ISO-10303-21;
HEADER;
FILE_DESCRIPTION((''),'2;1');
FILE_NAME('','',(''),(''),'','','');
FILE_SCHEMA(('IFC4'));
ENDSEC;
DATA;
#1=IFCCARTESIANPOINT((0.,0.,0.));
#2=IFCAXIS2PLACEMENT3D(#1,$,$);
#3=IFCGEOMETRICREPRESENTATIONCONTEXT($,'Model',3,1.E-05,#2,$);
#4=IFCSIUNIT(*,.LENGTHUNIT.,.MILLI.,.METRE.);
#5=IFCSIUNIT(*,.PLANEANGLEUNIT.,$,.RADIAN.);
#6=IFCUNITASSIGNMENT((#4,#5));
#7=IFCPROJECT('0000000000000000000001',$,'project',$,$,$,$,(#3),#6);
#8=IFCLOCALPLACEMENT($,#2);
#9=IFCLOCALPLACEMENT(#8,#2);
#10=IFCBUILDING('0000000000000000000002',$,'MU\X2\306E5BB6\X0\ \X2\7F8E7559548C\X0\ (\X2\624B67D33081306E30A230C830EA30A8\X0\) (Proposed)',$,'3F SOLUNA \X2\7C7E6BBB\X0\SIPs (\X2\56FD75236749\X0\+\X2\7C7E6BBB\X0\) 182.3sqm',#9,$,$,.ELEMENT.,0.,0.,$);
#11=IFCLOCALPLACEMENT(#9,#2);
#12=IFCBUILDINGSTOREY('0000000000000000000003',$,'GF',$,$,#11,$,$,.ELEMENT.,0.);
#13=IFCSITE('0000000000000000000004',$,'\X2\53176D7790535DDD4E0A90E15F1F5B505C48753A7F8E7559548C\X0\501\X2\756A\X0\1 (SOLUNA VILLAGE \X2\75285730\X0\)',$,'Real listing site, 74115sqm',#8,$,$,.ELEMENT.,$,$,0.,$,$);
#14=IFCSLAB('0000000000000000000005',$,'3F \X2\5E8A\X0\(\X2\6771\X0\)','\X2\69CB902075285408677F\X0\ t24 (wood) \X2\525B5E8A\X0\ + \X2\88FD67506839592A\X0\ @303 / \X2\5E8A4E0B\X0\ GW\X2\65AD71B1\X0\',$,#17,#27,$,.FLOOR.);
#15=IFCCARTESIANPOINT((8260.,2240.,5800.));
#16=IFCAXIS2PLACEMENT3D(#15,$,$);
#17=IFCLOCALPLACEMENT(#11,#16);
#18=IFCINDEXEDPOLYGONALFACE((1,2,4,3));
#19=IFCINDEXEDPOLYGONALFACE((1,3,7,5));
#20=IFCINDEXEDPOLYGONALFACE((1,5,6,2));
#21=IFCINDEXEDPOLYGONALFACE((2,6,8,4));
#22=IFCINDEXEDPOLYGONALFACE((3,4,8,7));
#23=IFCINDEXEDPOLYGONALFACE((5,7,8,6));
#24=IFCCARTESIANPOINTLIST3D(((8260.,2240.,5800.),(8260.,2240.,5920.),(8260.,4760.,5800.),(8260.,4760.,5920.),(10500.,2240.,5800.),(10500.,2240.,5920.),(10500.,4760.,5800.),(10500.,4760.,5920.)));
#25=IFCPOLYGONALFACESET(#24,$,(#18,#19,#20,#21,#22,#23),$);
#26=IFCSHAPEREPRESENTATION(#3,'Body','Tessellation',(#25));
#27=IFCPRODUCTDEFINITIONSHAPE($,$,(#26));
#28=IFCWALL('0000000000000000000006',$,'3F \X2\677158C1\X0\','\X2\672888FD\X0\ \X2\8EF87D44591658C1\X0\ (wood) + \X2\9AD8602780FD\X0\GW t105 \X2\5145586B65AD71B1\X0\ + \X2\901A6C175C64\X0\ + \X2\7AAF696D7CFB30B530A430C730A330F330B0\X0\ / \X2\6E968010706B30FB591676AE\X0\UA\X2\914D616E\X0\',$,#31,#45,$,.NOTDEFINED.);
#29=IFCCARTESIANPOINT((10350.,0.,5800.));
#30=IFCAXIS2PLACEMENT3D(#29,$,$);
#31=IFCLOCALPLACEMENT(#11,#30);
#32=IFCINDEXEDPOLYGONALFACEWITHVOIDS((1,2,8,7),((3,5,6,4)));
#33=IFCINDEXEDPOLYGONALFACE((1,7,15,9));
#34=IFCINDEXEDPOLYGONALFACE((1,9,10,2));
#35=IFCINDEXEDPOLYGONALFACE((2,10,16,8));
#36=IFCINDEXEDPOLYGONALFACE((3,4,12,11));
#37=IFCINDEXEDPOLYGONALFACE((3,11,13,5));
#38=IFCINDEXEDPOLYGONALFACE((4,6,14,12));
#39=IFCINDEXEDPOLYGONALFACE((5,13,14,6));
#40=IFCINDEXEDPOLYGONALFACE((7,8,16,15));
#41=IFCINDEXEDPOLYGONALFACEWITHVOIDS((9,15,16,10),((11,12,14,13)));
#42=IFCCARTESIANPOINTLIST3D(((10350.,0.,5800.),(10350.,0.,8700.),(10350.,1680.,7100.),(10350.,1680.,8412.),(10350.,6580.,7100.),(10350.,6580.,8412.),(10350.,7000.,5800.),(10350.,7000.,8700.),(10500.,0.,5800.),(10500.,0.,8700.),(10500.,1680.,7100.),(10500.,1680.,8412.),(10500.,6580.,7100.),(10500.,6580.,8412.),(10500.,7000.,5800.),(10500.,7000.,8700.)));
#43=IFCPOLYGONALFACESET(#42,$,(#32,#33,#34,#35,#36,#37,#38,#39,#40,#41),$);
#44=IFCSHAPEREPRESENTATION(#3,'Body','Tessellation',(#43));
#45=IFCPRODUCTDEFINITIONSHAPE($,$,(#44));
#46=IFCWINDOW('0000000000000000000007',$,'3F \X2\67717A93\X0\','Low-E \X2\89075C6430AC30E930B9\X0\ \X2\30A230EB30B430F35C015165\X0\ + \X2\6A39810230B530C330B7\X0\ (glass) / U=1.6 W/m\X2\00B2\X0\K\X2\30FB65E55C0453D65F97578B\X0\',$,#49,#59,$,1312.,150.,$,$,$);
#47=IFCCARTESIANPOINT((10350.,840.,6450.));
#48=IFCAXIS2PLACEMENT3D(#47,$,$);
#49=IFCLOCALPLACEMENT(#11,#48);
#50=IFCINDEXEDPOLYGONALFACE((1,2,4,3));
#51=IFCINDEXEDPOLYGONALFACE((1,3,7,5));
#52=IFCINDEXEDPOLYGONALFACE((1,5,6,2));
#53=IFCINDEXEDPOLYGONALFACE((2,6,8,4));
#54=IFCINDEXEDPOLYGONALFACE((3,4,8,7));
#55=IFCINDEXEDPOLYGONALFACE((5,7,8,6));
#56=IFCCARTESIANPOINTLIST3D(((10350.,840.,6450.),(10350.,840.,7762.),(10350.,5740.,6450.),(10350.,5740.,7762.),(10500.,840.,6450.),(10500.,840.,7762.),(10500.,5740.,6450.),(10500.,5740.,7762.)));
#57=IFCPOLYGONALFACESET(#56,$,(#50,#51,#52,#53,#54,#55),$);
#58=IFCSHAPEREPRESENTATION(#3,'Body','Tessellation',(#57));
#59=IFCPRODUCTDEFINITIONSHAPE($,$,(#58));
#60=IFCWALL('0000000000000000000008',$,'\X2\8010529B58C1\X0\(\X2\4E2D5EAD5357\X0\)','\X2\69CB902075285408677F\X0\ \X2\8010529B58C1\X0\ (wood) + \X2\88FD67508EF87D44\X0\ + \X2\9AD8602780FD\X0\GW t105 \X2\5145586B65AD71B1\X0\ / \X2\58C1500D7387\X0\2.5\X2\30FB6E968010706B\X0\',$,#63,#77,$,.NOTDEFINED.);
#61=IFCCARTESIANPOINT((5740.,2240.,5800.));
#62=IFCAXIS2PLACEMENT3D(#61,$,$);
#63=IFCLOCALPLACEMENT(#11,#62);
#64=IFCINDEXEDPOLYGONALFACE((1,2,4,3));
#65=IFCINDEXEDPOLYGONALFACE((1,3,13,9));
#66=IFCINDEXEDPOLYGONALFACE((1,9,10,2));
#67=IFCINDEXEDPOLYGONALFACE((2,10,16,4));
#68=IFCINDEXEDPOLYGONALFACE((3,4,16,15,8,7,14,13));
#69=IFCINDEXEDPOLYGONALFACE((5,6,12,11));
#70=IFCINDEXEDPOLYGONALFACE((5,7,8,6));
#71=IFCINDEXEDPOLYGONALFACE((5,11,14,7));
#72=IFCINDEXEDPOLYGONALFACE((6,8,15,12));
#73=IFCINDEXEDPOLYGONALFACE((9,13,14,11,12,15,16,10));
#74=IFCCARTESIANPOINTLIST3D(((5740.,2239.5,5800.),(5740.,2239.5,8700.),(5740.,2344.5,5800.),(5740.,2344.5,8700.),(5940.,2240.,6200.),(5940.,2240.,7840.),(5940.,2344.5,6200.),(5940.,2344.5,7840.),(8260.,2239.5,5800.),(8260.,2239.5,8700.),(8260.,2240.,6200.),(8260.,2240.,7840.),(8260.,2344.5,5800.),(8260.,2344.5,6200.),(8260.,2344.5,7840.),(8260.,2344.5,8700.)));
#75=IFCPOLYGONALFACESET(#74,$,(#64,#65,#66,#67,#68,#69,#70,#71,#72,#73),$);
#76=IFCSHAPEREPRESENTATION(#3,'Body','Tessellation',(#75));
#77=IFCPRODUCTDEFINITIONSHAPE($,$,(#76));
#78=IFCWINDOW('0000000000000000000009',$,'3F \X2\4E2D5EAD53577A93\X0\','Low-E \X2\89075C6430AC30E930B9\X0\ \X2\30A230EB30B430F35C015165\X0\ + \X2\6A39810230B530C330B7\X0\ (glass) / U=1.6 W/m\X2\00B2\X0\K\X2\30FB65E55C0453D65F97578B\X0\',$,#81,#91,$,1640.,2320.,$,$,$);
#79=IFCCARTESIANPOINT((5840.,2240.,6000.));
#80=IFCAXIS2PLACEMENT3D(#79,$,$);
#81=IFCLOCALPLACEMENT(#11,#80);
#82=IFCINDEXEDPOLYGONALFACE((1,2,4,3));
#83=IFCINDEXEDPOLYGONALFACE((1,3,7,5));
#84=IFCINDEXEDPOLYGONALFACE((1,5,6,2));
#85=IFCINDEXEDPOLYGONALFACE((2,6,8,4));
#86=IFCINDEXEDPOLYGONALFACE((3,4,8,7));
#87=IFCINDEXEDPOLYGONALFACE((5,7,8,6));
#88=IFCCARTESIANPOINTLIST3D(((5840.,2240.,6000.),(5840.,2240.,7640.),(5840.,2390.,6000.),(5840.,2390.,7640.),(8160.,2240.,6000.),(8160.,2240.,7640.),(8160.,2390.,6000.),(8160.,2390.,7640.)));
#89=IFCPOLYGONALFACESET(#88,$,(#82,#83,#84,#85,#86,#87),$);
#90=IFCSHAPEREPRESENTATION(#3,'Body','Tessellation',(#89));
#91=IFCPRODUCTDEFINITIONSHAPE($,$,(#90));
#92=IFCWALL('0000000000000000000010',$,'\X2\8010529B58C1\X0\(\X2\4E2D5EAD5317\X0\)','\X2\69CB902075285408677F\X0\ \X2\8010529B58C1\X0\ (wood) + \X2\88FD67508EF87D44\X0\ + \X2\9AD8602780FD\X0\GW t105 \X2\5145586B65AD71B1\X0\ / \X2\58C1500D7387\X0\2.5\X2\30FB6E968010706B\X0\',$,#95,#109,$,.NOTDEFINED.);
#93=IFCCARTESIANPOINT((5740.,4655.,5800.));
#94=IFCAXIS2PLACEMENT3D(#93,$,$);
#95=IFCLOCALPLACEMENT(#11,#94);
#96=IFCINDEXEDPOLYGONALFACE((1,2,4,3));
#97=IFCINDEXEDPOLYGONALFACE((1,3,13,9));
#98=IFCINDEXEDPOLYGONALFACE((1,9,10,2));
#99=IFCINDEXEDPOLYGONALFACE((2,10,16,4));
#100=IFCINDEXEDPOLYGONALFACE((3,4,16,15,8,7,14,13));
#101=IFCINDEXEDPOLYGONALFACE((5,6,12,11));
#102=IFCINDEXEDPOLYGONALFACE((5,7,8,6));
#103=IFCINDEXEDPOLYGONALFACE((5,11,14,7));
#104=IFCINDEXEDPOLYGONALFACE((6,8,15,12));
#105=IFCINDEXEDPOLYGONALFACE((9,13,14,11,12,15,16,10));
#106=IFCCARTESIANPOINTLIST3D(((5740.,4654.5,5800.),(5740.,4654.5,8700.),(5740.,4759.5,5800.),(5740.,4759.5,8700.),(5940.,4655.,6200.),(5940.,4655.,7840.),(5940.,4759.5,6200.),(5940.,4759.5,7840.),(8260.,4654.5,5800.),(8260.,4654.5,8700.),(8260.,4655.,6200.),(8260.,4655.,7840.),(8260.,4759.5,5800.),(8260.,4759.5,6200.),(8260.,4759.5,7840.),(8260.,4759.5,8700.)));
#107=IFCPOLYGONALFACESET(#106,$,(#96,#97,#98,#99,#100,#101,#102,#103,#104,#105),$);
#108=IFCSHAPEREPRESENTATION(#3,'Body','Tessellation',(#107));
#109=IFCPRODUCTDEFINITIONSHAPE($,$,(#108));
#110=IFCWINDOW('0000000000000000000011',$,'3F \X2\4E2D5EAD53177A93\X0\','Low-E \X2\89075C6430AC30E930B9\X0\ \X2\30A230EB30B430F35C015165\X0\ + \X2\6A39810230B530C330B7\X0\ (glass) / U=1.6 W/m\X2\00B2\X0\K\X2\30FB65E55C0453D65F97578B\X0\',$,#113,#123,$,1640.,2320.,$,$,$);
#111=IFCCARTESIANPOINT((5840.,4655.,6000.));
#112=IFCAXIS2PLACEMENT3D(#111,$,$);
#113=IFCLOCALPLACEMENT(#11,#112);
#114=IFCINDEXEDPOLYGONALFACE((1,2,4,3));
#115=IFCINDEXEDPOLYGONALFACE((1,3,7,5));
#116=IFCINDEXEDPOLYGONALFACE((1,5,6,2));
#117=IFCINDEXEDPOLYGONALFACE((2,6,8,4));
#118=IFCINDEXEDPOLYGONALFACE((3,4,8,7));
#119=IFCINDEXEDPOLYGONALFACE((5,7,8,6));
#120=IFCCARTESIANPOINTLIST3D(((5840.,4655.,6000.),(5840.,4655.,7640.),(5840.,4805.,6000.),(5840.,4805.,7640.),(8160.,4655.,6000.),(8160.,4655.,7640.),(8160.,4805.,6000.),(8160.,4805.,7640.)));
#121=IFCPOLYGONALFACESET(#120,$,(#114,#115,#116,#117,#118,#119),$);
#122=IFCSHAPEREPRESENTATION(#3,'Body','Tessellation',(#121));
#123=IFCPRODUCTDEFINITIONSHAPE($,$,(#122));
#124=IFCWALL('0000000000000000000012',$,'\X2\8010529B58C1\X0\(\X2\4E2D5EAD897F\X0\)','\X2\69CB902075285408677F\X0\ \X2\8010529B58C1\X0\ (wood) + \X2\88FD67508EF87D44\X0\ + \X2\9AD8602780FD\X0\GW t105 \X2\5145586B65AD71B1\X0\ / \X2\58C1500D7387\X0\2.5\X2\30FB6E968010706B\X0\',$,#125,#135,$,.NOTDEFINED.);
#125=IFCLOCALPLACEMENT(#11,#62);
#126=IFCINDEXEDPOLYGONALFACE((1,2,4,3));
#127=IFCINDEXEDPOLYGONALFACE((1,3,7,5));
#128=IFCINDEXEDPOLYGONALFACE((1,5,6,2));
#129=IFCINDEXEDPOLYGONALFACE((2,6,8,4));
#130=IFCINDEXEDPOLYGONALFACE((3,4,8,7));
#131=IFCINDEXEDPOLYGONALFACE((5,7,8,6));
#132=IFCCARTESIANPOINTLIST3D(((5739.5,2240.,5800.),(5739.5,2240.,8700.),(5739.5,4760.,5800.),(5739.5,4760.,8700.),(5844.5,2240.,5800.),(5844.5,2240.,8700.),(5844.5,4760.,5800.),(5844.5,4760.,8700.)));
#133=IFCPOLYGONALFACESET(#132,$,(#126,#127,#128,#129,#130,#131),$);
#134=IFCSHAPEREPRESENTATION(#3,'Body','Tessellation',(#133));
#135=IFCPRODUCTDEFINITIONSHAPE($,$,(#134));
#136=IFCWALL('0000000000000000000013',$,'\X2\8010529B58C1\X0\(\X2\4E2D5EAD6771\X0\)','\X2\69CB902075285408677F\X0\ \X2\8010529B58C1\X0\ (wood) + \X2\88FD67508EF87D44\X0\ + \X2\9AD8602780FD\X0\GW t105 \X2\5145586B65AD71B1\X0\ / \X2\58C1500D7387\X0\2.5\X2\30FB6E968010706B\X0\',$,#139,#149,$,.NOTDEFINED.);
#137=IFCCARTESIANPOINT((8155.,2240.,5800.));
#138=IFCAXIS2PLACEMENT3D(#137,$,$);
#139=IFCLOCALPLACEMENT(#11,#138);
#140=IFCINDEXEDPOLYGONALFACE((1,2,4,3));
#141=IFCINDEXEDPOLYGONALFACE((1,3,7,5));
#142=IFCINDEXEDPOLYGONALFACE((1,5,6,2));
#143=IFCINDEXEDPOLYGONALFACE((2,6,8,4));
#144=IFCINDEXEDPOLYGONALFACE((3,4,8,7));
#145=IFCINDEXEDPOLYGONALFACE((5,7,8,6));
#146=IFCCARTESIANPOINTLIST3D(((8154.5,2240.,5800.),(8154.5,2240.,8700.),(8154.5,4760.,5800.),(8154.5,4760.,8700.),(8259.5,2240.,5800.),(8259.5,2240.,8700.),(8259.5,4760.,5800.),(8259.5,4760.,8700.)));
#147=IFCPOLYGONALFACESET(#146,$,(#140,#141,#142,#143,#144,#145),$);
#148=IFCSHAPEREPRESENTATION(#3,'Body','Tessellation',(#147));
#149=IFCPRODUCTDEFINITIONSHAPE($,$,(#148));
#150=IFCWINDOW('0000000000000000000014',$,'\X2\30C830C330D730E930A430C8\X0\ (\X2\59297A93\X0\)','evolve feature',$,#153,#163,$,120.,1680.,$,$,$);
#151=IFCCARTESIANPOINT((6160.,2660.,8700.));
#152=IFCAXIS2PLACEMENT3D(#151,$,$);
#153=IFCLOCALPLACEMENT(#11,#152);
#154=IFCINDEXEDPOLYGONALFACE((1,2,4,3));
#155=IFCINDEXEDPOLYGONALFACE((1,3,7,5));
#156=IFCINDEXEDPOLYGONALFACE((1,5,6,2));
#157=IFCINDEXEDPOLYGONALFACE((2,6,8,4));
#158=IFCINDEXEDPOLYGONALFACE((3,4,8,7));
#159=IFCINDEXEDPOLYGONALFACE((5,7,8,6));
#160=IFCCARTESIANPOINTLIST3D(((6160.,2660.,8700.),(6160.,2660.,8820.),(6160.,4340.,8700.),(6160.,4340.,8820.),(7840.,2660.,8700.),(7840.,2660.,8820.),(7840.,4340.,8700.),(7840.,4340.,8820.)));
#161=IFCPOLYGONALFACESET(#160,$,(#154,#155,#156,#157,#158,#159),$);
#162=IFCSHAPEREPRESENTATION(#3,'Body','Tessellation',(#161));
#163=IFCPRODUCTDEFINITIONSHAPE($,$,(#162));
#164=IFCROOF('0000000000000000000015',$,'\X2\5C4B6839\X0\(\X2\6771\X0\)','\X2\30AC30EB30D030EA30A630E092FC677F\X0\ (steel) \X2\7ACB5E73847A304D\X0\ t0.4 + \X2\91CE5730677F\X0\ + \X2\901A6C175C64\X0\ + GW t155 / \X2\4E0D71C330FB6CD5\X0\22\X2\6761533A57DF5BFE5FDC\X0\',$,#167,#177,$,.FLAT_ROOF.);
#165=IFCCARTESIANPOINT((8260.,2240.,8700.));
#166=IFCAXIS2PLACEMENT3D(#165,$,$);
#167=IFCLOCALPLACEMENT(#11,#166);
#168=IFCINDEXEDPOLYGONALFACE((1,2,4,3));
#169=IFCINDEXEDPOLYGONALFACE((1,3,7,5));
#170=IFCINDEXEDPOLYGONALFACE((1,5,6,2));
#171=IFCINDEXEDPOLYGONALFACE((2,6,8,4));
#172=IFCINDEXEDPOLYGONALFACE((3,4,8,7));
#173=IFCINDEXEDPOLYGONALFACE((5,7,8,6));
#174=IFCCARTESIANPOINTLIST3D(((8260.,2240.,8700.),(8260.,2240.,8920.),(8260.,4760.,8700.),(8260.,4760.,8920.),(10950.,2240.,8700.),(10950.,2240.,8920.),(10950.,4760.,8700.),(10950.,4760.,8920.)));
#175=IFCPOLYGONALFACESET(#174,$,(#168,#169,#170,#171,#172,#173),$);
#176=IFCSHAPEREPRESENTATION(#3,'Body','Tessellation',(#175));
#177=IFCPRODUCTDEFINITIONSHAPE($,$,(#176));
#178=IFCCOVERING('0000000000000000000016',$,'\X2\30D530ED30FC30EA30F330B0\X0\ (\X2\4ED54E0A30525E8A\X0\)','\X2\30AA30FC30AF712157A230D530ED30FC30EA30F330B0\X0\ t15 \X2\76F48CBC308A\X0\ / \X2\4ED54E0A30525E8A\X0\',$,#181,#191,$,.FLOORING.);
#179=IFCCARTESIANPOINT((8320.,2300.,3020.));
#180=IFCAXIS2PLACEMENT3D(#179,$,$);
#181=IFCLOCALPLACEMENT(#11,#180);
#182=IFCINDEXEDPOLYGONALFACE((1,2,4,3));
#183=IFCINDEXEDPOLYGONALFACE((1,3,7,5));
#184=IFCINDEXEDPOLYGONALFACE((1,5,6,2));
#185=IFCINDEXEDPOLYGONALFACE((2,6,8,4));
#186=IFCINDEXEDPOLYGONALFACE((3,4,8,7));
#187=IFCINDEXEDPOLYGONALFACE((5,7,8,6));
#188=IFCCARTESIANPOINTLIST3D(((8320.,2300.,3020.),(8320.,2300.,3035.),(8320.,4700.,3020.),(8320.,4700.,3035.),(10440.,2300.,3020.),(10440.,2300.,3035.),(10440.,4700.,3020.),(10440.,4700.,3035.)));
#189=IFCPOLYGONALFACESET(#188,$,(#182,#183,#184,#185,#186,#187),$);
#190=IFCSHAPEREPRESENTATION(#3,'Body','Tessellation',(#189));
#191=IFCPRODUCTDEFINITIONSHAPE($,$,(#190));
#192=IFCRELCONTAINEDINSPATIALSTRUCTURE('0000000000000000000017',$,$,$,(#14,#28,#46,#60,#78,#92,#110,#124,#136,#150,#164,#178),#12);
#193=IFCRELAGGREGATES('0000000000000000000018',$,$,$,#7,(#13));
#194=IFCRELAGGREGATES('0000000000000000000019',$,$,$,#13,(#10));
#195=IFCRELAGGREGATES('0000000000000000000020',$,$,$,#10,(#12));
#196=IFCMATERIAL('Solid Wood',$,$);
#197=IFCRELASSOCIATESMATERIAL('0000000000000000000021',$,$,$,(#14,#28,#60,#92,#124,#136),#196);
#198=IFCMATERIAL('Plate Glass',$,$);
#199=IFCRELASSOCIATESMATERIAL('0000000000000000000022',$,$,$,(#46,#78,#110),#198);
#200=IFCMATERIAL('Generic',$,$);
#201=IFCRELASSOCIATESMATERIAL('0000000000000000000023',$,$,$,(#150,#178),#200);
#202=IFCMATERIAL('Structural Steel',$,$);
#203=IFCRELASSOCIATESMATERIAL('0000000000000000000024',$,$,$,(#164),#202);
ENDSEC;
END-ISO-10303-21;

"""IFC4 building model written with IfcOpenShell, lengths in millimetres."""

from ifc_helpers import new_model, si_unit, frame, frame_2d, origin, place, context, project, spatial, rectangle, extrude, material, element, fill, save


model = new_model("IFC4")

# Units and contexts
model_context = context("Model", 3, precision=1e-05, world=origin())
ifc_project = project(units=[si_unit("LENGTHUNIT", "METRE", prefix="MILLI"), si_unit("PLANEANGLEUNIT", "RADIAN")], contexts=[model_context])

# Site, building, storey
site_placement = place(None, origin())
site = spatial("IfcSite", under=ifc_project, at=site_placement, Name="北海道川上郡弟子屈町美留和501番1 (SOLUNA VILLAGE 用地)", ObjectType="Real listing site, 74115sqm", CompositionType="ELEMENT", RefElevation=0.0)
building_placement = place(site_placement, origin())
building = spatial("IfcBuilding", under=site, at=building_placement, Name="MUの家 美留和 (手染めのアトリエ) (Proposed)", ObjectType="3F SOLUNA 籾殻SIPs (国産杉+籾殻) 182.3sqm", CompositionType="ELEMENT", ElevationOfRefHeight=0.0, ElevationOfTerrain=0.0)
storey_placement = place(building_placement, origin())
storey = spatial("IfcBuildingStorey", under=building, at=storey_placement, Name="GF", CompositionType="ELEMENT", Elevation=0.0)

# Slab
ifc_material_1 = material(Name="Solid Wood")
slab_placement = place(storey_placement, frame((8260.0, 2240.0, 5800.0)))
element("IfcSlab", 1, at=slab_placement, inside=storey, material=ifc_material_1, Name="3F 床(東)", Description="構造用合板 t24 (wood) 剛床 + 製材根太 @303 / 床下 GW断熱", PredefinedType="FLOOR", context=model_context, shape_type="SweptSolid", body=[
    extrude(rectangle(XDim=2240.0, YDim=2520.0, at=frame_2d((1120.0, 1260.0))), frame((8260.0, 2240.0, 5800.0)), (0.0, 0.0, 1.0), 120.0),
])

# Walls, openings, windows
wall_1_placement = place(storey_placement, frame((10350.0, 0.0, 5800.0)))
wall_1 = element("IfcWall", 2, at=wall_1_placement, inside=storey, material=ifc_material_1, Name="3F 東壁", Description="木製 軸組外壁 (wood) + 高性能GW t105 充填断熱 + 通気層 + 窯業系サイディング / 準耐火・外皮UA配慮", PredefinedType="NOTDEFINED", context=model_context, shape_type="SweptSolid", body=[
    extrude(rectangle(XDim=150.0, YDim=7000.0, at=frame_2d((75.0, 3500.0))), frame((10350.0, 0.0, 5800.0)), (0.0, 0.0, 1.0), 2900.0),
])
opening_1_placement = place(storey_placement, frame((10350.0, 840.0, 6450.0)))
opening_1 = element("IfcOpeningElement", 3, at=opening_1_placement, cuts=wall_1, PredefinedType="NOTDEFINED", context=model_context, shape_type="SweptSolid", body=[
    extrude(rectangle(XDim=150.0, YDim=4900.0, at=frame_2d((75.0, 2450.0))), frame((10350.0, 840.0, 6450.0)), (0.0, 0.0, 1.0), 1312.0),
])
ifc_material_2 = material(Name="Plate Glass")
window_1_placement = place(storey_placement, frame((10350.0, 840.0, 6450.0)))
window_1 = element("IfcWindow", 4, at=window_1_placement, inside=storey, material=ifc_material_2, Name="3F 東窓", Description="Low-E 複層ガラス アルゴン封入 + 樹脂サッシ (glass) / U=1.6 W/m²K・日射取得型", OverallHeight=1312.0, OverallWidth=150.0, context=model_context, shape_type="SweptSolid", body=[
    extrude(rectangle(XDim=150.0, YDim=4900.0, at=frame_2d((75.0, 2450.0))), frame((10350.0, 840.0, 6450.0)), (0.0, 0.0, 1.0), 1312.0),
])
fill(opening_1, window_1)
wall_2_placement = place(storey_placement, frame((5740.0, 2240.0, 5800.0)))
wall_2 = element("IfcWall", 5, at=wall_2_placement, inside=storey, material=ifc_material_1, Name="耐力壁(中庭南)", Description="構造用合板 耐力壁 (wood) + 製材軸組 + 高性能GW t105 充填断熱 / 壁倍率2.5・準耐火", PredefinedType="NOTDEFINED", context=model_context, shape_type="SweptSolid", body=[
    extrude(rectangle(XDim=2520.0, YDim=105.0, at=frame_2d((1260.0, 52.0))), frame((5740.0, 2240.0, 5800.0)), (0.0, 0.0, 1.0), 2900.0),
])
opening_2_placement = place(storey_placement, frame((5840.0, 2240.0, 6000.0)))
opening_2 = element("IfcOpeningElement", 6, at=opening_2_placement, cuts=wall_2, PredefinedType="NOTDEFINED", context=model_context, shape_type="SweptSolid", body=[
    extrude(rectangle(XDim=2320.0, YDim=150.0, at=frame_2d((1160.0, 75.0))), frame((5840.0, 2240.0, 6000.0)), (0.0, 0.0, 1.0), 1640.0),
])
window_2_placement = place(storey_placement, frame((5840.0, 2240.0, 6000.0)))
window_2 = element("IfcWindow", 7, at=window_2_placement, inside=storey, material=ifc_material_2, Name="3F 中庭南窓", Description="Low-E 複層ガラス アルゴン封入 + 樹脂サッシ (glass) / U=1.6 W/m²K・日射取得型", OverallHeight=1640.0, OverallWidth=2320.0, context=model_context, shape_type="SweptSolid", body=[
    extrude(rectangle(XDim=2320.0, YDim=150.0, at=frame_2d((1160.0, 75.0))), frame((5840.0, 2240.0, 6000.0)), (0.0, 0.0, 1.0), 1640.0),
])
fill(opening_2, window_2)
wall_3_placement = place(storey_placement, frame((5740.0, 4655.0, 5800.0)))
wall_3 = element("IfcWall", 8, at=wall_3_placement, inside=storey, material=ifc_material_1, Name="耐力壁(中庭北)", Description="構造用合板 耐力壁 (wood) + 製材軸組 + 高性能GW t105 充填断熱 / 壁倍率2.5・準耐火", PredefinedType="NOTDEFINED", context=model_context, shape_type="SweptSolid", body=[
    extrude(rectangle(XDim=2520.0, YDim=105.0, at=frame_2d((1260.0, 52.0))), frame((5740.0, 4655.0, 5800.0)), (0.0, 0.0, 1.0), 2900.0),
])
opening_3_placement = place(storey_placement, frame((5840.0, 4655.0, 6000.0)))
opening_3 = element("IfcOpeningElement", 9, at=opening_3_placement, cuts=wall_3, PredefinedType="NOTDEFINED", context=model_context, shape_type="SweptSolid", body=[
    extrude(rectangle(XDim=2320.0, YDim=150.0, at=frame_2d((1160.0, 75.0))), frame((5840.0, 4655.0, 6000.0)), (0.0, 0.0, 1.0), 1640.0),
])
window_3_placement = place(storey_placement, frame((5840.0, 4655.0, 6000.0)))
window_3 = element("IfcWindow", 10, at=window_3_placement, inside=storey, material=ifc_material_2, Name="3F 中庭北窓", Description="Low-E 複層ガラス アルゴン封入 + 樹脂サッシ (glass) / U=1.6 W/m²K・日射取得型", OverallHeight=1640.0, OverallWidth=2320.0, context=model_context, shape_type="SweptSolid", body=[
    extrude(rectangle(XDim=2320.0, YDim=150.0, at=frame_2d((1160.0, 75.0))), frame((5840.0, 4655.0, 6000.0)), (0.0, 0.0, 1.0), 1640.0),
])
fill(opening_3, window_3)

# Walls
wall_4_placement = place(storey_placement, frame((5740.0, 2240.0, 5800.0)))
element("IfcWall", 11, at=wall_4_placement, inside=storey, material=ifc_material_1, Name="耐力壁(中庭西)", Description="構造用合板 耐力壁 (wood) + 製材軸組 + 高性能GW t105 充填断熱 / 壁倍率2.5・準耐火", PredefinedType="NOTDEFINED", context=model_context, shape_type="SweptSolid", body=[
    extrude(rectangle(XDim=105.0, YDim=2520.0, at=frame_2d((52.0, 1260.0))), frame((5740.0, 2240.0, 5800.0)), (0.0, 0.0, 1.0), 2900.0),
])
wall_5_placement = place(storey_placement, frame((8155.0, 2240.0, 5800.0)))
element("IfcWall", 12, at=wall_5_placement, inside=storey, material=ifc_material_1, Name="耐力壁(中庭東)", Description="構造用合板 耐力壁 (wood) + 製材軸組 + 高性能GW t105 充填断熱 / 壁倍率2.5・準耐火", PredefinedType="NOTDEFINED", context=model_context, shape_type="SweptSolid", body=[
    extrude(rectangle(XDim=105.0, YDim=2520.0, at=frame_2d((52.0, 1260.0))), frame((8155.0, 2240.0, 5800.0)), (0.0, 0.0, 1.0), 2900.0),
])

# Window
ifc_material_3 = material(Name="Generic")
window_4_placement = place(storey_placement, frame((6160.0, 2660.0, 8700.0)))
element("IfcWindow", 13, at=window_4_placement, inside=storey, material=ifc_material_3, Name="トップライト (天窓)", Description="evolve feature", OverallHeight=120.0, OverallWidth=1680.0, context=model_context, shape_type="SweptSolid", body=[
    extrude(rectangle(XDim=1680.0, YDim=1680.0, at=frame_2d((840.0, 840.0))), frame((6160.0, 2660.0, 8700.0)), (0.0, 0.0, 1.0), 120.0),
])

# Roof
ifc_material_4 = material(Name="Structural Steel")
for number, where, name in (
    (14, (8260.0, 2240.0, 8700.0), "屋根(東)"),
):
    element("IfcRoof", number, at=place(storey_placement, frame(where)), inside=storey, material=ifc_material_4, Name=name, Description="ガルバリウム鋼板 (steel) 立平葺き t0.4 + 野地板 + 通気層 + GW t155 / 不燃・法22条区域対応", PredefinedType="FLAT_ROOF", context=model_context, shape_type="SweptSolid", body=[
        extrude(rectangle(XDim=2690.0, YDim=2520.0, at=frame_2d((1345.0, 1260.0))), frame((8260.0, 2240.0, 8700.0)), (0.0, 0.0, 1.0), 220.0),
    ])

# Covering
covering_1_placement = place(storey_placement, frame((8320.0, 2300.0, 3020.0)))
element("IfcCovering", 15, at=covering_1_placement, inside=storey, material=ifc_material_3, Name="フローリング (仕上げ床)", Description="オーク無垢フローリング t15 直貼り / 仕上げ床", PredefinedType="FLOORING", context=model_context, shape_type="SweptSolid", body=[
    extrude(rectangle(XDim=2120.0, YDim=2400.0, at=frame_2d((1060.0, 1200.0))), frame((8320.0, 2300.0, 3020.0)), (0.0, 0.0, 1.0), 15.0),
])

save(model, "model.ifc")
